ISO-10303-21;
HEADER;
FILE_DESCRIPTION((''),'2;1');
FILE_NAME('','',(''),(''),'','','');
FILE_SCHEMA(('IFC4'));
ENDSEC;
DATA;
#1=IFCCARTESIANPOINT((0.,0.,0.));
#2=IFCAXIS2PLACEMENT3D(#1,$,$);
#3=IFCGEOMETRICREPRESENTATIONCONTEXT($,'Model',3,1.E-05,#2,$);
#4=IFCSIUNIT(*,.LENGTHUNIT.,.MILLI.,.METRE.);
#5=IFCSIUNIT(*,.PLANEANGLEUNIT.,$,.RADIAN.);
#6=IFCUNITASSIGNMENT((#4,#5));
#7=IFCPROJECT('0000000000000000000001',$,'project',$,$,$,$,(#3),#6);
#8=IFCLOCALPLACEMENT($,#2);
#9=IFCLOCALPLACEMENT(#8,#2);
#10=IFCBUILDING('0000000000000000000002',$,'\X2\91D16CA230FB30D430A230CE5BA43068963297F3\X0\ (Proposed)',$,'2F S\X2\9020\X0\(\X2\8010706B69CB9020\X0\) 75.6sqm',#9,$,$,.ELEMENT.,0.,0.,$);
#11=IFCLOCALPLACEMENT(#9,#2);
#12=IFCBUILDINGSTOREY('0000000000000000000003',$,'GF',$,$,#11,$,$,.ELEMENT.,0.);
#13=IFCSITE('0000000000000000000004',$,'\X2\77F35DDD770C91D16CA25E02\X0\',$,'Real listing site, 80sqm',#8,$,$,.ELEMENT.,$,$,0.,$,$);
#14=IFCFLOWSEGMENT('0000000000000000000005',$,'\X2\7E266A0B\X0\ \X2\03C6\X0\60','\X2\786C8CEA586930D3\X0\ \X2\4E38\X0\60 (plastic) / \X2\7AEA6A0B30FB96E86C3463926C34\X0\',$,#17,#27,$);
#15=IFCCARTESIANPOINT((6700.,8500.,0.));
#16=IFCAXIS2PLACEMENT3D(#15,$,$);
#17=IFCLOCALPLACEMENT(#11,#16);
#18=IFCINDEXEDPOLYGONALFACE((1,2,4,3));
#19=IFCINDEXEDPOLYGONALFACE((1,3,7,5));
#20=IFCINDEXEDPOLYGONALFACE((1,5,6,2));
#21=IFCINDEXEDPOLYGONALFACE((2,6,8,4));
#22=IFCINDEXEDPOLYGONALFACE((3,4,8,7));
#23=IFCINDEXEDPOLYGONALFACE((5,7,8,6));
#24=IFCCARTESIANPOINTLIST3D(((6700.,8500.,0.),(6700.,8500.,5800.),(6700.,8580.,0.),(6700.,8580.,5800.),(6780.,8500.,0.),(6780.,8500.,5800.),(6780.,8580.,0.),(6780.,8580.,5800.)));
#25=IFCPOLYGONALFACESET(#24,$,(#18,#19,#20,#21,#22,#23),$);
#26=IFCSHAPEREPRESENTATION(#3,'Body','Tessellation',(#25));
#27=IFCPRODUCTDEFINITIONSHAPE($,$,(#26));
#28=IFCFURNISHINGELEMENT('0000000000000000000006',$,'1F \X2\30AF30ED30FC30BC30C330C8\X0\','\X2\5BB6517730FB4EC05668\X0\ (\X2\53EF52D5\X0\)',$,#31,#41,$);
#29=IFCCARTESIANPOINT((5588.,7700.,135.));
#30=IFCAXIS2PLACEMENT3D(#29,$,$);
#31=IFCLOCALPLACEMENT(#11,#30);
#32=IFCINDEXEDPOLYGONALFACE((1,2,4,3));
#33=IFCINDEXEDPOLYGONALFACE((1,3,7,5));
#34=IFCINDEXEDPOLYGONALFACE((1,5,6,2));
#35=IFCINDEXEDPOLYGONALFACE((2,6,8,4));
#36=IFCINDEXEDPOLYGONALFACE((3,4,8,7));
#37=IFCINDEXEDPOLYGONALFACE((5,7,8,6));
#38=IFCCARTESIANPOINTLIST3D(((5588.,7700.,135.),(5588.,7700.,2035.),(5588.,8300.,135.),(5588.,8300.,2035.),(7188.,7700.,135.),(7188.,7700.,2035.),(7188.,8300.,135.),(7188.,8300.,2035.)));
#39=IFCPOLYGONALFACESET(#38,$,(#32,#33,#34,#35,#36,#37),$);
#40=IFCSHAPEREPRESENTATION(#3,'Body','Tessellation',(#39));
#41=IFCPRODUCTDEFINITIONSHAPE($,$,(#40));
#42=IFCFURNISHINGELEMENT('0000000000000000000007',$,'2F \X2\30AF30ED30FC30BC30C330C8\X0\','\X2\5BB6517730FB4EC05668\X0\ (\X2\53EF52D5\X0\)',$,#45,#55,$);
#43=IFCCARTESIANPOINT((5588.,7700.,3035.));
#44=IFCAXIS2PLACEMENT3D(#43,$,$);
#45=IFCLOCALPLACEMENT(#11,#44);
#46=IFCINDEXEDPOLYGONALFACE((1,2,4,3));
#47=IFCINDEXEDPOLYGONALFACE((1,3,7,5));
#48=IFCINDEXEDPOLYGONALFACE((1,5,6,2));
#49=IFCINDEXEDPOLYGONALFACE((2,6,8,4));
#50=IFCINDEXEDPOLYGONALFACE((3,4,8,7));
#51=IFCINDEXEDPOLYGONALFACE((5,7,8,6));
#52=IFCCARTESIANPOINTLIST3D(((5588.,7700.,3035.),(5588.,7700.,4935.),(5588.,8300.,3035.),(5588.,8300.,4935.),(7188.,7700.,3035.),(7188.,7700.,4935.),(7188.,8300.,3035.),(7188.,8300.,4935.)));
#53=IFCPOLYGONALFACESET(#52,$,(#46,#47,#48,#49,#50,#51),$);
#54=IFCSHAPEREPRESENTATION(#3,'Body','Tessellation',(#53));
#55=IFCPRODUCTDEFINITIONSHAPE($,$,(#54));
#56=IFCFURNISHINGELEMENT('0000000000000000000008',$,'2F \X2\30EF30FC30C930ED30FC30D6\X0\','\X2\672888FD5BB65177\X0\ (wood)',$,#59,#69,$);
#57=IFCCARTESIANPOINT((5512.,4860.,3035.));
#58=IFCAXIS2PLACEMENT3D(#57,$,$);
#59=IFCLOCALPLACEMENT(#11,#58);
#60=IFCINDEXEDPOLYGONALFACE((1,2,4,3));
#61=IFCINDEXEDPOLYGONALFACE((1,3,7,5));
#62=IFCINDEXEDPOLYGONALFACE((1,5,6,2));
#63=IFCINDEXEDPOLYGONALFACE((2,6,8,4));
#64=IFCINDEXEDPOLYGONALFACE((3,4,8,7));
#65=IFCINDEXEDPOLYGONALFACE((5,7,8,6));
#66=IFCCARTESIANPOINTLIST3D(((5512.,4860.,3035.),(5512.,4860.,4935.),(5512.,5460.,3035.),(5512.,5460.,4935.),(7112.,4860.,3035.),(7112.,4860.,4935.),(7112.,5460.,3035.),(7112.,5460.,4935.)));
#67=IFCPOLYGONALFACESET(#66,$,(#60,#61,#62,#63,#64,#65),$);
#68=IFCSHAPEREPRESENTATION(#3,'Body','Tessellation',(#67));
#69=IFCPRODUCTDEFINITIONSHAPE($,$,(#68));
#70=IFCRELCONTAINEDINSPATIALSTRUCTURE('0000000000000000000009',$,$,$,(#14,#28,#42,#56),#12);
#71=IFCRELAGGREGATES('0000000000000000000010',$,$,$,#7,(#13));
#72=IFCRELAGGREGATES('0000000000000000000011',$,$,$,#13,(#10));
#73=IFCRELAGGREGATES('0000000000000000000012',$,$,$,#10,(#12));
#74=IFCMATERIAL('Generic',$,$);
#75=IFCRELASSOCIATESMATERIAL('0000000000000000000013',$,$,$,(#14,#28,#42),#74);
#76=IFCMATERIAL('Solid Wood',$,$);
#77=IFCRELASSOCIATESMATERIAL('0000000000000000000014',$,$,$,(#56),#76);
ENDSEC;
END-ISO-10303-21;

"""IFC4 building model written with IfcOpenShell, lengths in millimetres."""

from ifc_helpers import new_model, si_unit, frame, frame_2d, origin, place, context, project, spatial, rectangle, extrude, material, element, save


model = new_model("IFC4")

# Units and contexts
model_context = context("Model", 3, precision=1e-05, world=origin())
ifc_project = project(units=[si_unit("LENGTHUNIT", "METRE", prefix="MILLI"), si_unit("PLANEANGLEUNIT", "RADIAN")], contexts=[model_context])

# Site, building, storey
site_placement = place(None, origin())
site = spatial("IfcSite", under=ifc_project, at=site_placement, Name="石川県金沢市", ObjectType="Real listing site, 80sqm", CompositionType="ELEMENT", RefElevation=0.0)
building_placement = place(site_placement, origin())
building = spatial("IfcBuilding", under=site, at=building_placement, Name="金沢・ピアノ室と防音 (Proposed)", ObjectType="2F S造(耐火構造) 75.6sqm", CompositionType="ELEMENT", ElevationOfRefHeight=0.0, ElevationOfTerrain=0.0)
storey_placement = place(building_placement, origin())
storey = spatial("IfcBuildingStorey", under=building, at=storey_placement, Name="GF", CompositionType="ELEMENT", Elevation=0.0)

# Shared definitions
ifc_material_1 = material(Name="Solid Wood")

# Shared definitions
ifc_material_2 = material(Name="Generic")

# Flow segment
flow_segment_placement = place(storey_placement, frame((6700.0, 8500.0, 0.0)))
element("IfcFlowSegment", 1, at=flow_segment_placement, inside=storey, material=ifc_material_2, Name="縦樋 φ60", Description="硬質塩ビ 丸60 (plastic) / 竪樋・雨水排水", context=model_context, shape_type="SweptSolid", body=[
    extrude(rectangle(XDim=80.0, YDim=80.0, at=frame_2d((40.0, 40.0))), frame((6700.0, 8500.0, 0.0)), (0.0, 0.0, 1.0), 5800.0),
])

# Furnishing elements
furnishing_1_placement = place(storey_placement, frame((5588.0, 7700.0, 135.0)))
element("IfcFurnishingElement", 2, at=furnishing_1_placement, inside=storey, material=ifc_material_2, Name="1F クローゼット", Description="家具・什器 (可動)", context=model_context, shape_type="SweptSolid", body=[
    extrude(rectangle(XDim=1600.0, YDim=600.0, at=frame_2d((800.0, 300.0))), frame((5588.0, 7700.0, 135.0)), (0.0, 0.0, 1.0), 1900.0),
])
furnishing_2_placement = place(storey_placement, frame((5588.0, 7700.0, 3035.0)))
element("IfcFurnishingElement", 3, at=furnishing_2_placement, inside=storey, material=ifc_material_2, Name="2F クローゼット", Description="家具・什器 (可動)", context=model_context, shape_type="SweptSolid", body=[
    extrude(rectangle(XDim=1600.0, YDim=600.0, at=frame_2d((800.0, 300.0))), frame((5588.0, 7700.0, 3035.0)), (0.0, 0.0, 1.0), 1900.0),
])
furnishing_3_placement = place(storey_placement, frame((5512.0, 4860.0, 3035.0)))
element("IfcFurnishingElement", 4, at=furnishing_3_placement, inside=storey, material=ifc_material_1, Name="2F ワードローブ", Description="木製家具 (wood)", context=model_context, shape_type="SweptSolid", body=[
    extrude(rectangle(XDim=1600.0, YDim=600.0, at=frame_2d((800.0, 300.0))), frame((5512.0, 4860.0, 3035.0)), (0.0, 0.0, 1.0), 1900.0),
])

save(model, "model.ifc")
